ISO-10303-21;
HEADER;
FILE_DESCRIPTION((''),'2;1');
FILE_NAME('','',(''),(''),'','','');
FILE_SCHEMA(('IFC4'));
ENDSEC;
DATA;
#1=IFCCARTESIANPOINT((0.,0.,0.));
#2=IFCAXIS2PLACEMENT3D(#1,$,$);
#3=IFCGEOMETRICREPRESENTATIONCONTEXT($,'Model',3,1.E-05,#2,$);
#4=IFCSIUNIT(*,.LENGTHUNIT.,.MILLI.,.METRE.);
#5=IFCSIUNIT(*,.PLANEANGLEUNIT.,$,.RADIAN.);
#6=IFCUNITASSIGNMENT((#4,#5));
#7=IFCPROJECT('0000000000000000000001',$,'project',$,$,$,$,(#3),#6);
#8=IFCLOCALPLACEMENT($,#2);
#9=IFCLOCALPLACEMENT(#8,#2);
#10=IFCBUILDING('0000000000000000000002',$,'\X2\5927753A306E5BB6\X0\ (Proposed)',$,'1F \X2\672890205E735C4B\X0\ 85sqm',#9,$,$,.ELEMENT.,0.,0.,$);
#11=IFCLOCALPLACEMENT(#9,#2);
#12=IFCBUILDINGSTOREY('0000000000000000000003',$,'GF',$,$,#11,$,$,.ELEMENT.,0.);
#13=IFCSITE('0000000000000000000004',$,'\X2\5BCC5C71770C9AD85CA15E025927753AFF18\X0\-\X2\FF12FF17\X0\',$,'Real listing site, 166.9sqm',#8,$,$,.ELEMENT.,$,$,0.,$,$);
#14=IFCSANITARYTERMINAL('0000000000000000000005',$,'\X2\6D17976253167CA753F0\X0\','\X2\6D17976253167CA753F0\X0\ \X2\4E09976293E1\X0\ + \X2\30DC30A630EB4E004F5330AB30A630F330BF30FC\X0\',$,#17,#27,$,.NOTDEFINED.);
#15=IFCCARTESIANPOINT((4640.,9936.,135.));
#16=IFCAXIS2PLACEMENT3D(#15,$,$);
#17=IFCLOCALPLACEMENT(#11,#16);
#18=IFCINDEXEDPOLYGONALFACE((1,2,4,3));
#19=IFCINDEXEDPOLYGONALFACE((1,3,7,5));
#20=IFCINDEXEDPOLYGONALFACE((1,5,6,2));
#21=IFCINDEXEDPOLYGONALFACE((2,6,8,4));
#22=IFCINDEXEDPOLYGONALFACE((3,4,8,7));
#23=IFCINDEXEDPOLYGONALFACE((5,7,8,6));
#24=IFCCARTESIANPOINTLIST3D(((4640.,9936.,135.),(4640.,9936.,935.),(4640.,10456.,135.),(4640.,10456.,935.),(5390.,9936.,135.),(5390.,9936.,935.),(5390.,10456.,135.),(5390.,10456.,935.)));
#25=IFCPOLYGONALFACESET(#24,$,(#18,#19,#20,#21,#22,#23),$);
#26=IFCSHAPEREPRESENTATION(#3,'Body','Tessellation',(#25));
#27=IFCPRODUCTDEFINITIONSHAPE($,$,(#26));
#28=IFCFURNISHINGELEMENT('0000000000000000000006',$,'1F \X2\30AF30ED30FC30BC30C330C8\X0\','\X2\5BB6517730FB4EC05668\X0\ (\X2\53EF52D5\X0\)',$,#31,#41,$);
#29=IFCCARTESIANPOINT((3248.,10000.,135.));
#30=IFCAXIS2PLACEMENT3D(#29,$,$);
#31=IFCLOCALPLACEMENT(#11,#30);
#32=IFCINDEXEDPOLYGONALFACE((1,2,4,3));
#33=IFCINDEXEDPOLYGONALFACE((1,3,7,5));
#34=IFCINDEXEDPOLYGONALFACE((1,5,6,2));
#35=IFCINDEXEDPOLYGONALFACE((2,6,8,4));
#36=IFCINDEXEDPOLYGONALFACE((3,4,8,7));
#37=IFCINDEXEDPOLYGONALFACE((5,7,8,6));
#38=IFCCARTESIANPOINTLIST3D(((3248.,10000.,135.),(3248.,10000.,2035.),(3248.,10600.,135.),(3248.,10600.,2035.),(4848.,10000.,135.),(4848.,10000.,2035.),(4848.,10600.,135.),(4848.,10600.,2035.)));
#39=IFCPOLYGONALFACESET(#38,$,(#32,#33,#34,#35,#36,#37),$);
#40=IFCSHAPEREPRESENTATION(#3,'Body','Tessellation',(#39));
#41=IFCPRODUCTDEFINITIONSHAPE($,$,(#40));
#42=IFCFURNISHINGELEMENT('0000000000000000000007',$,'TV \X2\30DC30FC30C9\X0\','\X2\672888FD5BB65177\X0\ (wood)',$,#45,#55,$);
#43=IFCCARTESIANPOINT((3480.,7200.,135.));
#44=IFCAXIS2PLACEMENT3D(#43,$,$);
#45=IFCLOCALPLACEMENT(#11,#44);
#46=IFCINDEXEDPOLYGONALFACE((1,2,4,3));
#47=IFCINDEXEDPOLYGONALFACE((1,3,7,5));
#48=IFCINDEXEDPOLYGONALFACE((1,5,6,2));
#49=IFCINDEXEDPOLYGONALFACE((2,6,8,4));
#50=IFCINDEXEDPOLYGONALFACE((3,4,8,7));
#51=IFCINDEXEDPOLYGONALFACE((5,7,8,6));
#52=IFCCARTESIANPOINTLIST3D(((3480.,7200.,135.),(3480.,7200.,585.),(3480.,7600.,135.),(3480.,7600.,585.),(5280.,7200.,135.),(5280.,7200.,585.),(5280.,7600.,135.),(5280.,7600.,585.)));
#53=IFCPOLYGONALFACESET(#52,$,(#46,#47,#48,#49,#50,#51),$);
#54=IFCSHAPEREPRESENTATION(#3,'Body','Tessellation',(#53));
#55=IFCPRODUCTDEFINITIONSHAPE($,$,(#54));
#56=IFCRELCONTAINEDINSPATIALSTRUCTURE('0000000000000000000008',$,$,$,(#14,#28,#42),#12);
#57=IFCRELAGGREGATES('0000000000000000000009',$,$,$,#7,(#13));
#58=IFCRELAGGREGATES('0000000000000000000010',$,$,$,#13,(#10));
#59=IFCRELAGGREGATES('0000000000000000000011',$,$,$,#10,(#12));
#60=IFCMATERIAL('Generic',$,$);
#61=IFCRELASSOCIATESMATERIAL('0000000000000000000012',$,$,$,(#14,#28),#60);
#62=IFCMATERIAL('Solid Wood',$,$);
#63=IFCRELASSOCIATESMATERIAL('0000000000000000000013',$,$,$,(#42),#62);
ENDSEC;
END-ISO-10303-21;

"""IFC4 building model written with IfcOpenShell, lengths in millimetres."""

from ifc_helpers import new_model, si_unit, frame, frame_2d, origin, place, context, project, spatial, rectangle, extrude, material, element, save


model = new_model("IFC4")

# Units and contexts
model_context = context("Model", 3, precision=1e-05, world=origin())
ifc_project = project(units=[si_unit("LENGTHUNIT", "METRE", prefix="MILLI"), si_unit("PLANEANGLEUNIT", "RADIAN")], contexts=[model_context])

# Site, building, storey
site_placement = place(None, origin())
site = spatial("IfcSite", under=ifc_project, at=site_placement, Name="富山県高岡市大町８-２７", ObjectType="Real listing site, 166.9sqm", CompositionType="ELEMENT", RefElevation=0.0)
building_placement = place(site_placement, origin())
building = spatial("IfcBuilding", under=site, at=building_placement, Name="大町の家 (Proposed)", ObjectType="1F 木造平屋 85sqm", CompositionType="ELEMENT", ElevationOfRefHeight=0.0, ElevationOfTerrain=0.0)
storey_placement = place(building_placement, origin())
storey = spatial("IfcBuildingStorey", under=building, at=storey_placement, Name="GF", CompositionType="ELEMENT", Elevation=0.0)

# Shared definitions
ifc_material_1 = material(Name="Solid Wood")

# Shared definitions
ifc_material_2 = material(Name="Generic")

# Sanitary terminal
sanitary_terminal_1_placement = place(storey_placement, frame((4640.0, 9936.0, 135.0)))
element("IfcSanitaryTerminal", 1, at=sanitary_terminal_1_placement, inside=storey, material=ifc_material_2, Name="洗面化粧台", Description="洗面化粧台 三面鏡 + ボウル一体カウンター", PredefinedType="NOTDEFINED", context=model_context, shape_type="SweptSolid", body=[
    extrude(rectangle(XDim=750.0, YDim=520.0, at=frame_2d((375.0, 260.0))), frame((4640.0, 9936.0, 135.0)), (0.0, 0.0, 1.0), 800.0),
])

# Furnishing elements
furnishing_1_placement = place(storey_placement, frame((3248.0, 10000.0, 135.0)))
element("IfcFurnishingElement", 2, at=furnishing_1_placement, inside=storey, material=ifc_material_2, Name="1F クローゼット", Description="家具・什器 (可動)", context=model_context, shape_type="SweptSolid", body=[
    extrude(rectangle(XDim=1600.0, YDim=600.0, at=frame_2d((800.0, 300.0))), frame((3248.0, 10000.0, 135.0)), (0.0, 0.0, 1.0), 1900.0),
])
furnishing_2_placement = place(storey_placement, frame((3480.0, 7200.0, 135.0)))
element("IfcFurnishingElement", 3, at=furnishing_2_placement, inside=storey, material=ifc_material_1, Name="TV ボード", Description="木製家具 (wood)", context=model_context, shape_type="SweptSolid", body=[
    extrude(rectangle(XDim=1800.0, YDim=400.0, at=frame_2d((900.0, 200.0))), frame((3480.0, 7200.0, 135.0)), (0.0, 0.0, 1.0), 450.0),
])

save(model, "model.ifc")
